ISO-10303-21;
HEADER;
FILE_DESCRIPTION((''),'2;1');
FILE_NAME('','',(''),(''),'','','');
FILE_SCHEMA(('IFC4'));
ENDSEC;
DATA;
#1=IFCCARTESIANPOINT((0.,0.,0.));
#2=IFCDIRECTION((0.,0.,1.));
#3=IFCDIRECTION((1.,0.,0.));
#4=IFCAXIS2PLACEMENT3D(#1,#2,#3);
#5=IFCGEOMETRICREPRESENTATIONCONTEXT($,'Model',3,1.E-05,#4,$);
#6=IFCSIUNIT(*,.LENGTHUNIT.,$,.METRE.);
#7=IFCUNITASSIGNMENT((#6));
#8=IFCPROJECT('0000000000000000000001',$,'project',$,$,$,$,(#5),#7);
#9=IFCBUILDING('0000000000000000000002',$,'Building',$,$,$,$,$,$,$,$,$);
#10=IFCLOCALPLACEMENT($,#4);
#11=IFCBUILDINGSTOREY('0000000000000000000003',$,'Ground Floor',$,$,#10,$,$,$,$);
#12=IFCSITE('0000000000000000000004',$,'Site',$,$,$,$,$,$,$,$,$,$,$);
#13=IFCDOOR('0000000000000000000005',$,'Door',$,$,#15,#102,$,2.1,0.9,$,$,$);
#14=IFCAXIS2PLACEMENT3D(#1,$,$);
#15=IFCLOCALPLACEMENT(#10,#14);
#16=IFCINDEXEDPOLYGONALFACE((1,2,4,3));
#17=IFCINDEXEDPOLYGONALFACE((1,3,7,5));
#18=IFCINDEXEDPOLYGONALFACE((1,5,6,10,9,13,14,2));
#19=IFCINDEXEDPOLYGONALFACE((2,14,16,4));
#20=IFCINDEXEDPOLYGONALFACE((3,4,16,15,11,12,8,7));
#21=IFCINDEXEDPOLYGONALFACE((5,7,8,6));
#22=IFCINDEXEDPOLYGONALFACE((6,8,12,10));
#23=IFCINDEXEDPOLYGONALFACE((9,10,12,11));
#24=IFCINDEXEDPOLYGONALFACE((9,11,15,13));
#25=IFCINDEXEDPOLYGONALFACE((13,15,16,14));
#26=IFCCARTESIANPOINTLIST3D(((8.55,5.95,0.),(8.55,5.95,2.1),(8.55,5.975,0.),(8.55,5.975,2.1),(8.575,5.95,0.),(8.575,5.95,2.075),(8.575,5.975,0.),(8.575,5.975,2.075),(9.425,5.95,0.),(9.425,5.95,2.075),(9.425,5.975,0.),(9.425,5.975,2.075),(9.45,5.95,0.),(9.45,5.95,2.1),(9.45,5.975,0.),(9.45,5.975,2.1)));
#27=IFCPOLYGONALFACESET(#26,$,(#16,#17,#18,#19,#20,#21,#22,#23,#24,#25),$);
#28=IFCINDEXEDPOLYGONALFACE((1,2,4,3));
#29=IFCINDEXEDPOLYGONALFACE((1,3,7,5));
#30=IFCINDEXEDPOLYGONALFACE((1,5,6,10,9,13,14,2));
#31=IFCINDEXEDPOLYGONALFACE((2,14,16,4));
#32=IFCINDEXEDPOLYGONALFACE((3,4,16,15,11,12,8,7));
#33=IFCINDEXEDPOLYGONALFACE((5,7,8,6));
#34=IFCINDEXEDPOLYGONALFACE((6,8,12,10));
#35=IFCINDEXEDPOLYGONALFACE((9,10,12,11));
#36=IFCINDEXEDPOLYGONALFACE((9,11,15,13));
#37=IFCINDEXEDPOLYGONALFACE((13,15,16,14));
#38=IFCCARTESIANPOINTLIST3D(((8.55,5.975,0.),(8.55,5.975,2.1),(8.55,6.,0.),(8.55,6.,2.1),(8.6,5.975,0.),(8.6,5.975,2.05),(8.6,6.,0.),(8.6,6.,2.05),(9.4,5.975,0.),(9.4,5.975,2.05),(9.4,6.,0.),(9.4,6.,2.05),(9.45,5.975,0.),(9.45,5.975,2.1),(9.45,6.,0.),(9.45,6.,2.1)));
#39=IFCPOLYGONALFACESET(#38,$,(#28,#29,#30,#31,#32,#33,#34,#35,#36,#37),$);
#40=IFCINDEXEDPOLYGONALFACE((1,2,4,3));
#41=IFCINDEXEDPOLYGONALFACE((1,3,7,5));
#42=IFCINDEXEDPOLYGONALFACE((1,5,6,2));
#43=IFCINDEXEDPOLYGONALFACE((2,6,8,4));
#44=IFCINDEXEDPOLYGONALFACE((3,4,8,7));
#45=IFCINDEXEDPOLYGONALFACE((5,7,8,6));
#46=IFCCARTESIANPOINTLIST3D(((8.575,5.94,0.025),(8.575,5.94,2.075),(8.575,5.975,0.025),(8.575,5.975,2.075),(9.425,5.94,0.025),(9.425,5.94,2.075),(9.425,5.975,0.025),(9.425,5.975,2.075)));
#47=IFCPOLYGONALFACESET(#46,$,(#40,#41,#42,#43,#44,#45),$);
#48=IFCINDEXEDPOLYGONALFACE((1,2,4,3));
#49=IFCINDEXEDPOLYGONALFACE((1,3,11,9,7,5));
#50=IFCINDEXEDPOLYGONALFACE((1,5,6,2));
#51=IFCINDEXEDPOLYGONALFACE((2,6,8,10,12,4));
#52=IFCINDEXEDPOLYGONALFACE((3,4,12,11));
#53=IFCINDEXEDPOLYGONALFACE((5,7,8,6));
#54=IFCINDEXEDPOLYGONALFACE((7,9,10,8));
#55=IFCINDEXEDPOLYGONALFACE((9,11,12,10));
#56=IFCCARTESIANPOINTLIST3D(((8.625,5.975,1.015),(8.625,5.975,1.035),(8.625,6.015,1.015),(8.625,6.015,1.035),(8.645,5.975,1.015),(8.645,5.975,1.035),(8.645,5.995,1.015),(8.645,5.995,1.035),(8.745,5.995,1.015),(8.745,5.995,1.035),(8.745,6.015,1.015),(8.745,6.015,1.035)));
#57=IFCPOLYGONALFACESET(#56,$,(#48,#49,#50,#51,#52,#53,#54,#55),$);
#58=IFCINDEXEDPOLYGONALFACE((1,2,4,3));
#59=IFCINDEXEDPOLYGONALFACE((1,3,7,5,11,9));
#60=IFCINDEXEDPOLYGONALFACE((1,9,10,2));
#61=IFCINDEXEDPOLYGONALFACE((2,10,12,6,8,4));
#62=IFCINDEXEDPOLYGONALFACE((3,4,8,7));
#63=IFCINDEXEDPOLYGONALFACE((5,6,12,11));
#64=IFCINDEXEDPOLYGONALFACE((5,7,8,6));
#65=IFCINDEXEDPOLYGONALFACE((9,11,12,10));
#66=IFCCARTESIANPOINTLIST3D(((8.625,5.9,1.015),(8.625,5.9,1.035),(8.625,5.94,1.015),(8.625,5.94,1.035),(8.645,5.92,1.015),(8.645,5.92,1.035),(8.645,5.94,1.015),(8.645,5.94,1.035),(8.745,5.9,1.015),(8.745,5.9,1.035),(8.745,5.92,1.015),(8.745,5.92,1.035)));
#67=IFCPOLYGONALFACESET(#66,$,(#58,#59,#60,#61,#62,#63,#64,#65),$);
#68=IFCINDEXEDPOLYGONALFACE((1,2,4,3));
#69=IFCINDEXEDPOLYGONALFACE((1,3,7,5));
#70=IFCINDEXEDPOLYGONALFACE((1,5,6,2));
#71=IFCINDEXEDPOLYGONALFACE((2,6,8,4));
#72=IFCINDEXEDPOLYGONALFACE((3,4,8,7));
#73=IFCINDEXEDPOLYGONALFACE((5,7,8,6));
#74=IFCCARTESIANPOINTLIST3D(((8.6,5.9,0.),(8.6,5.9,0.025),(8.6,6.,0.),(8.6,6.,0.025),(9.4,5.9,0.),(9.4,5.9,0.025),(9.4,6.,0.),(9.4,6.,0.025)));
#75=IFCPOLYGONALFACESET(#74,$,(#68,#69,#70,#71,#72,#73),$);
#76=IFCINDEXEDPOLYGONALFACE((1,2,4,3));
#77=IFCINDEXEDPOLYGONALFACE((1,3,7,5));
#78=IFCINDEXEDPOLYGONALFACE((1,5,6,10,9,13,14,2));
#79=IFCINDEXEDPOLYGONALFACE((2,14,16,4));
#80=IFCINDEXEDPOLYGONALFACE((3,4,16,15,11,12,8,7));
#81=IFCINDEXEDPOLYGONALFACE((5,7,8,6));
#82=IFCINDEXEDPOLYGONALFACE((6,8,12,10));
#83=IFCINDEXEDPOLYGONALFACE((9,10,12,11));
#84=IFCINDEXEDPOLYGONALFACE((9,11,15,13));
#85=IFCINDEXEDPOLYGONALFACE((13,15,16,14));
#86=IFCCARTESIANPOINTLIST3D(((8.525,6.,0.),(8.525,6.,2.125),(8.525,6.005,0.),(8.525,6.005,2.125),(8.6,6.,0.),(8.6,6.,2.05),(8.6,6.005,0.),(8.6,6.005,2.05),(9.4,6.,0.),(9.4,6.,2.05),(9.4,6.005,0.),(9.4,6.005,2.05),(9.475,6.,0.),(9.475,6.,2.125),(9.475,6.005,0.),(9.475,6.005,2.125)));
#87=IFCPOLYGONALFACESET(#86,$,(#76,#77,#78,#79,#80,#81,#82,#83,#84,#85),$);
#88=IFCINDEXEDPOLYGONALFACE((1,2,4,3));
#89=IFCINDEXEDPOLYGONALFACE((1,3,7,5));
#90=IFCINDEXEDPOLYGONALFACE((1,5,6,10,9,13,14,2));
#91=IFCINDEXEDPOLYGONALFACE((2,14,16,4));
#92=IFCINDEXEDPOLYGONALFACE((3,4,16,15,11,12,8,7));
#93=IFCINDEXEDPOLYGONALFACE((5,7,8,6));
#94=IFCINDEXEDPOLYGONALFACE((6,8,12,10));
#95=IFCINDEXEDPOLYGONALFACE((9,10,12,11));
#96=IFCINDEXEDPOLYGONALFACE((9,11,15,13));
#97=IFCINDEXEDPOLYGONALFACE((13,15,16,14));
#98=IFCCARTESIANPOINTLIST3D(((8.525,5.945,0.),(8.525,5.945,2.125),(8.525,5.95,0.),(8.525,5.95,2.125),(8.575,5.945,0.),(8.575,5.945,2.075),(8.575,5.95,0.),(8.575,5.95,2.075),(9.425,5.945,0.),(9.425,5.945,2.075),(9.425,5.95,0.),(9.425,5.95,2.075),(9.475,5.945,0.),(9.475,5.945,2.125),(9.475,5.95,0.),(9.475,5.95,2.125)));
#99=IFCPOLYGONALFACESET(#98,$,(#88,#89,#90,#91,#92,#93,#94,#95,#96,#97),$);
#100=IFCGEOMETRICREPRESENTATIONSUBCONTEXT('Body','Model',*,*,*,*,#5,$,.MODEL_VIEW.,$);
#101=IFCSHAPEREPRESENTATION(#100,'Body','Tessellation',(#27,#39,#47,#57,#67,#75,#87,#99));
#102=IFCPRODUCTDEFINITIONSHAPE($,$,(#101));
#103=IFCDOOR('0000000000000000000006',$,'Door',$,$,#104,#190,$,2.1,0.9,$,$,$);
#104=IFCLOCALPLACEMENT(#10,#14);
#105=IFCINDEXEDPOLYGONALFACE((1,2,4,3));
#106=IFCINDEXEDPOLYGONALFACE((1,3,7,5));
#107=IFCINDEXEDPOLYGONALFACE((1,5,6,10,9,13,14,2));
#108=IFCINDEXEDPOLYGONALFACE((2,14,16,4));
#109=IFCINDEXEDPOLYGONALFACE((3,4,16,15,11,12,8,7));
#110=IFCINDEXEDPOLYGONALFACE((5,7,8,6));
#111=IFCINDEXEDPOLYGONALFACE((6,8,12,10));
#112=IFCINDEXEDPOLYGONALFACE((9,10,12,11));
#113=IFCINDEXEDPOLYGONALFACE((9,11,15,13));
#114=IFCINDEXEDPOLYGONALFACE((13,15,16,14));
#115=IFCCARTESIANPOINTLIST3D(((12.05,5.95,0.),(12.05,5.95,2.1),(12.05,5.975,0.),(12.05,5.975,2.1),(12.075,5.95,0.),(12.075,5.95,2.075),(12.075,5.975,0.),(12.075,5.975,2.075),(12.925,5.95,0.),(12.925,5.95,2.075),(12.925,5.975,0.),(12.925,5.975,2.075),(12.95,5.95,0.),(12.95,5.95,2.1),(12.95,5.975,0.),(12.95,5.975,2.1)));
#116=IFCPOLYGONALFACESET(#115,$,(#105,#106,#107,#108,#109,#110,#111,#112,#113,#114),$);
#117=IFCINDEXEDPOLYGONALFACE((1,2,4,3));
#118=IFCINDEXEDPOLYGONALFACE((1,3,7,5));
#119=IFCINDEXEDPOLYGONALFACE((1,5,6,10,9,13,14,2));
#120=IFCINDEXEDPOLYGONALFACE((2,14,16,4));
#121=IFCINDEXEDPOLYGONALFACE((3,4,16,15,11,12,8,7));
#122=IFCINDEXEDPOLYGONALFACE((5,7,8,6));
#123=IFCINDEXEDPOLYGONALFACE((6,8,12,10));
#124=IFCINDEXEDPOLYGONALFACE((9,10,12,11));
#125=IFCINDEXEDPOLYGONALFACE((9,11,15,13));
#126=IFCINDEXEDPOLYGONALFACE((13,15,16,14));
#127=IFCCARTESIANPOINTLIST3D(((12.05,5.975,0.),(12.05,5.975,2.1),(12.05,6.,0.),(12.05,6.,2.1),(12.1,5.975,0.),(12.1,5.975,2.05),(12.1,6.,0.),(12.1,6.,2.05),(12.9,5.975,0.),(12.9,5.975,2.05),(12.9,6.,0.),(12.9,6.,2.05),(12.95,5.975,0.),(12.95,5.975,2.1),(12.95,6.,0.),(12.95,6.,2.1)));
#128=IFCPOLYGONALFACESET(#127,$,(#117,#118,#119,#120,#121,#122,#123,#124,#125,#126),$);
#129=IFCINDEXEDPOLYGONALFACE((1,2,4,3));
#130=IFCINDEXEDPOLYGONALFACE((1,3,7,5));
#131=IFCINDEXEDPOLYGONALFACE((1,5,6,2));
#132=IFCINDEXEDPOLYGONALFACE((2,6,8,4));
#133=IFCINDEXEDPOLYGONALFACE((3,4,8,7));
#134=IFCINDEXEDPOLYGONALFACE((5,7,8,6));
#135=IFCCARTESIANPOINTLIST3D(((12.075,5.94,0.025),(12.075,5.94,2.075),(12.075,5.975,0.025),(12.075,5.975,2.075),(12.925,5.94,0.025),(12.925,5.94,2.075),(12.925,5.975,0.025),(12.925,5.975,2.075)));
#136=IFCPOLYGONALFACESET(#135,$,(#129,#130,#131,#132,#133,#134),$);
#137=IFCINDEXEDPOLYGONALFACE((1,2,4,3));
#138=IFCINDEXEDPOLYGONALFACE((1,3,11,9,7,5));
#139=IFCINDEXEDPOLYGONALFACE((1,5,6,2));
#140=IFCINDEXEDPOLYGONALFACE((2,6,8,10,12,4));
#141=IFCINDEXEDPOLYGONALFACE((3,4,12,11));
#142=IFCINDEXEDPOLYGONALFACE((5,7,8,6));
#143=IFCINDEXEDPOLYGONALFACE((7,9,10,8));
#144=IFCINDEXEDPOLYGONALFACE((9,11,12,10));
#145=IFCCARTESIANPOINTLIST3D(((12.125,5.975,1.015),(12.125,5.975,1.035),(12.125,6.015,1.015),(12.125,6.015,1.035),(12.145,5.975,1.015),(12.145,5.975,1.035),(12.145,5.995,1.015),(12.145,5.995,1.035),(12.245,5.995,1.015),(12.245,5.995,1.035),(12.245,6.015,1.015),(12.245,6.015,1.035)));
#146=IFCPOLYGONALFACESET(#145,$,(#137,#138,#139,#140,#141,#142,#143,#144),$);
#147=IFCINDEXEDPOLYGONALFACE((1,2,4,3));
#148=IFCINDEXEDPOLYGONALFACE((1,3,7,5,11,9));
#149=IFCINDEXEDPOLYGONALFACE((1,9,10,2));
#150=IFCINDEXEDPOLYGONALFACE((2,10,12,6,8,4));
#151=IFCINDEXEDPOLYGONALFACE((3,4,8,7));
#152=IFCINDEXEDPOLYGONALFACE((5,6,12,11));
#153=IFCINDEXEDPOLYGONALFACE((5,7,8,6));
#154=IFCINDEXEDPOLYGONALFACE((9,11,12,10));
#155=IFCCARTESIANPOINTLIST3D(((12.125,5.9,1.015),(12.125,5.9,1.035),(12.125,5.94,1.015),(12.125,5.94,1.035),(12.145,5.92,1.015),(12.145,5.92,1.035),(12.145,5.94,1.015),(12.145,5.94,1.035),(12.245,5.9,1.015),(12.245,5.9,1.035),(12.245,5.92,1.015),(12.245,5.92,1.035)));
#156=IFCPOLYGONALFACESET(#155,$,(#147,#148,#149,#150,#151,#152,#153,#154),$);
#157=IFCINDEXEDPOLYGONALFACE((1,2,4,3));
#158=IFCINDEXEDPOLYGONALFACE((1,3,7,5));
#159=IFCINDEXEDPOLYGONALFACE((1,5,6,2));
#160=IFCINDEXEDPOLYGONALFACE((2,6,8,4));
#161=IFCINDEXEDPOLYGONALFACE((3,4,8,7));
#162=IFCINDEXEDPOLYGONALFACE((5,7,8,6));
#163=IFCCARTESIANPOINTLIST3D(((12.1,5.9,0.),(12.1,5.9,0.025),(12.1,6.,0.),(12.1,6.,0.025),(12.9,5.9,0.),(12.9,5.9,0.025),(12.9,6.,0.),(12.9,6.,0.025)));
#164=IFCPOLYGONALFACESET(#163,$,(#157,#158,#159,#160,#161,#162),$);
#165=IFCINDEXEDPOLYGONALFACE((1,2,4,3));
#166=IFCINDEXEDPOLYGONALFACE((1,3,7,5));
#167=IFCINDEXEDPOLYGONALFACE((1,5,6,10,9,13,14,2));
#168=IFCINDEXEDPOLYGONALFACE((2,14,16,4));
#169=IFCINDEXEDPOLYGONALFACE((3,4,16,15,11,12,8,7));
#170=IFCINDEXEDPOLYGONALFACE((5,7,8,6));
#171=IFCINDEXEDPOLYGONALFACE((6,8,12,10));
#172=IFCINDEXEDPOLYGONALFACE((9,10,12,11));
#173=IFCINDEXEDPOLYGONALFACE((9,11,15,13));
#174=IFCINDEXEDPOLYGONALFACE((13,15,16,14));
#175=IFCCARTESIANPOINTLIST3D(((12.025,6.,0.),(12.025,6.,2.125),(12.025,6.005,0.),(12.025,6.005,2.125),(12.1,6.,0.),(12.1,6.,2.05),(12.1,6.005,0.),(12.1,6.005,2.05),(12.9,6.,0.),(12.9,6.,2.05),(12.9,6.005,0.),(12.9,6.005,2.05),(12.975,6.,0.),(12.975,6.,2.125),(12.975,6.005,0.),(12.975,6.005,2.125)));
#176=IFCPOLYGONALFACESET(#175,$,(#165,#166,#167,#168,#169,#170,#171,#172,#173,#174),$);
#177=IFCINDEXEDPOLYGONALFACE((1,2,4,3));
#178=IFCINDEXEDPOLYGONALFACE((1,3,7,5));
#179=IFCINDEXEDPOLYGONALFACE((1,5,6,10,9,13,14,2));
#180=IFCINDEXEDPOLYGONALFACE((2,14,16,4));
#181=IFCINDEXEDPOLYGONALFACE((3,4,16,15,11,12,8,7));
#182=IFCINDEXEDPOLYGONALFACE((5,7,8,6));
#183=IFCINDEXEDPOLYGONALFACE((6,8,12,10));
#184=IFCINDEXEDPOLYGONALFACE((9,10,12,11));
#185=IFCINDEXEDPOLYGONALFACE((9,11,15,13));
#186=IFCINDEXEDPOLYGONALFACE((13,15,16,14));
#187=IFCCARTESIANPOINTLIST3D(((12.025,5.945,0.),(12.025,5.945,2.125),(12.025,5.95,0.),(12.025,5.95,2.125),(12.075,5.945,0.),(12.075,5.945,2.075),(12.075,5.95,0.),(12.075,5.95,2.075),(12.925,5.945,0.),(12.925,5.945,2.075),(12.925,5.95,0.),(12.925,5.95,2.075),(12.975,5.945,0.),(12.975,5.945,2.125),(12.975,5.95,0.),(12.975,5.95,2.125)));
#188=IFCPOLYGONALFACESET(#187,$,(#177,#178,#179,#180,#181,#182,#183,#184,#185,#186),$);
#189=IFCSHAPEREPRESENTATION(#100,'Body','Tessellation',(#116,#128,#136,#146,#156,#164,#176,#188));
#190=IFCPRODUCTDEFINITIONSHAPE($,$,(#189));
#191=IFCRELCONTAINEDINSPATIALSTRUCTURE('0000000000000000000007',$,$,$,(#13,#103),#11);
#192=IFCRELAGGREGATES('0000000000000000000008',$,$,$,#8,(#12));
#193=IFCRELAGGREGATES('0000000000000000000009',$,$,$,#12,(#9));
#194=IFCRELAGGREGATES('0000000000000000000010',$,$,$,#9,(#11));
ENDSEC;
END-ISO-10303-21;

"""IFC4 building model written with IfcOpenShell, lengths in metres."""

from ifc_helpers import new_model, si_unit, frame, origin_with_axes, place, context, subcontext, project, spatial, line, indexed_curve, outline, extrude, element, save


model = new_model("IFC4")

# Units and contexts
model_context = context("Model", 3, precision=1e-05, world=origin_with_axes())
body_context = subcontext(model_context, "Body", "Model", "MODEL_VIEW")
ifc_project = project(units=[si_unit("LENGTHUNIT", "METRE")], contexts=[model_context])

# Site, building, storey
site = spatial("IfcSite", under=ifc_project, Name="Site")
building = spatial("IfcBuilding", under=site, Name="Building")
storey_placement = place(None, origin_with_axes())
storey = spatial("IfcBuildingStorey", under=building, at=storey_placement, Name="Ground Floor")

# Doors
door_1_placement = place(storey_placement, frame((9.45, 6.0, 0.0), z_axis=(0.0, 0.0, 1.0), x_axis=(-1.0, 0.0, 0.0)))
element("IfcDoor", 1, at=door_1_placement, inside=storey, Name="Door", OverallHeight=2.1, OverallWidth=0.9, context=body_context, shape_type="SweptSolid", body=[
    extrude(outline(indexed_curve([(0.0, 0.0), (0.0, 2.1), (0.9, 2.1), (0.9, 0.0), (0.875, 0.0), (0.875, 2.075), (0.025, 2.075), (0.025, 0.0)], segments=[line(1, 2, 3, 4, 5, 6, 7, 8, 1)])), frame((0.0, 0.025, 0.0), z_axis=(0.0, -1.0, 0.0), x_axis=(1.0, 0.0, 0.0)), (0.0, 0.0, -1.0), 0.025),
    extrude(outline(indexed_curve([(0.0, 0.0), (0.0, 2.1), (0.9, 2.1), (0.9, 0.0), (0.85, 0.0), (0.85, 2.05), (0.05, 2.05), (0.05, 0.0)], segments=[line(1, 2, 3, 4, 5, 6, 7, 8, 1)])), frame((0.0, 0.0, 0.0), z_axis=(0.0, -1.0, 0.0), x_axis=(1.0, 0.0, 0.0)), (0.0, 0.0, -1.0), 0.025),
    extrude(outline(indexed_curve([(0.0, 0.0), (0.85, 0.0), (0.85, 0.035), (0.0, 0.035)], segments=[line(1, 2, 3, 4, 1)])), frame((0.025, 0.025, 0.025), z_axis=(0.0, 0.0, 1.0), x_axis=(1.0, 0.0, 0.0)), (0.0, 0.0, 1.0), 2.05),
    extrude(outline(indexed_curve([(0.0, 0.0), (0.0, -0.04), (-0.12, -0.04), (-0.12, -0.02), (-0.02, -0.02), (-0.02, 0.0)], segments=[line(1, 2, 3, 4, 5, 6, 1)])), frame((0.825, 0.025, 1.015), z_axis=(0.0, 0.0, 1.0), x_axis=(1.0, 0.0, 0.0)), (0.0, 0.0, 1.0), 0.02),
    extrude(outline(indexed_curve([(0.0, 0.0), (0.0, 0.04), (-0.12, 0.04), (-0.12, 0.02), (-0.02, 0.02), (-0.02, 0.0)], segments=[line(1, 2, 3, 4, 5, 6, 1)])), frame((0.825, 0.06, 1.015), z_axis=(0.0, 0.0, 1.0), x_axis=(1.0, 0.0, 0.0)), (0.0, 0.0, 1.0), 0.02),
    extrude(outline(indexed_curve([(0.0, 0.0), (0.8, 0.0), (0.8, 0.1), (0.0, 0.1)], segments=[line(1, 2, 3, 4, 1)])), frame((0.05, 0.0, 0.0), z_axis=(0.0, 0.0, 1.0), x_axis=(1.0, 0.0, 0.0)), (0.0, 0.0, 1.0), 0.025),
    extrude(outline(indexed_curve([(0.0, 0.0), (0.0, 2.125), (0.95, 2.125), (0.95, 0.0), (0.875, 0.0), (0.875, 2.05), (0.075, 2.05), (0.075, 0.0)], segments=[line(1, 2, 3, 4, 5, 6, 7, 8, 1)])), frame((-0.025, -0.005, 0.0), z_axis=(0.0, -1.0, 0.0), x_axis=(1.0, 0.0, 0.0)), (0.0, 0.0, -1.0), 0.005),
    extrude(outline(indexed_curve([(0.0, 0.0), (0.0, 2.125), (0.95, 2.125), (0.95, 0.0), (0.9, 0.0), (0.9, 2.075), (0.05, 2.075), (0.05, 0.0)], segments=[line(1, 2, 3, 4, 5, 6, 7, 8, 1)])), frame((-0.025, 0.05, 0.0), z_axis=(0.0, -1.0, 0.0), x_axis=(1.0, 0.0, 0.0)), (0.0, 0.0, -1.0), 0.005),
])
door_2_placement = place(storey_placement, frame((12.95, 6.0, 0.0), z_axis=(0.0, 0.0, 1.0), x_axis=(-1.0, 0.0, 0.0)))
element("IfcDoor", 2, at=door_2_placement, inside=storey, Name="Door", OverallHeight=2.1, OverallWidth=0.9, context=body_context, shape_type="SweptSolid", body=[
    extrude(outline(indexed_curve([(0.0, 0.0), (0.0, 2.1), (0.9, 2.1), (0.9, 0.0), (0.875, 0.0), (0.875, 2.075), (0.025, 2.075), (0.025, 0.0)], segments=[line(1, 2, 3, 4, 5, 6, 7, 8, 1)])), frame((0.0, 0.025, 0.0), z_axis=(0.0, -1.0, 0.0), x_axis=(1.0, 0.0, 0.0)), (0.0, 0.0, -1.0), 0.025),
    extrude(outline(indexed_curve([(0.0, 0.0), (0.0, 2.1), (0.9, 2.1), (0.9, 0.0), (0.85, 0.0), (0.85, 2.05), (0.05, 2.05), (0.05, 0.0)], segments=[line(1, 2, 3, 4, 5, 6, 7, 8, 1)])), frame((0.0, 0.0, 0.0), z_axis=(0.0, -1.0, 0.0), x_axis=(1.0, 0.0, 0.0)), (0.0, 0.0, -1.0), 0.025),
    extrude(outline(indexed_curve([(0.0, 0.0), (0.85, 0.0), (0.85, 0.035), (0.0, 0.035)], segments=[line(1, 2, 3, 4, 1)])), frame((0.025, 0.025, 0.025), z_axis=(0.0, 0.0, 1.0), x_axis=(1.0, 0.0, 0.0)), (0.0, 0.0, 1.0), 2.05),
    extrude(outline(indexed_curve([(0.0, 0.0), (0.0, -0.04), (-0.12, -0.04), (-0.12, -0.02), (-0.02, -0.02), (-0.02, 0.0)], segments=[line(1, 2, 3, 4, 5, 6, 1)])), frame((0.825, 0.025, 1.015), z_axis=(0.0, 0.0, 1.0), x_axis=(1.0, 0.0, 0.0)), (0.0, 0.0, 1.0), 0.02),
    extrude(outline(indexed_curve([(0.0, 0.0), (0.0, 0.04), (-0.12, 0.04), (-0.12, 0.02), (-0.02, 0.02), (-0.02, 0.0)], segments=[line(1, 2, 3, 4, 5, 6, 1)])), frame((0.825, 0.06, 1.015), z_axis=(0.0, 0.0, 1.0), x_axis=(1.0, 0.0, 0.0)), (0.0, 0.0, 1.0), 0.02),
    extrude(outline(indexed_curve([(0.0, 0.0), (0.8, 0.0), (0.8, 0.1), (0.0, 0.1)], segments=[line(1, 2, 3, 4, 1)])), frame((0.05, 0.0, 0.0), z_axis=(0.0, 0.0, 1.0), x_axis=(1.0, 0.0, 0.0)), (0.0, 0.0, 1.0), 0.025),
    extrude(outline(indexed_curve([(0.0, 0.0), (0.0, 2.125), (0.95, 2.125), (0.95, 0.0), (0.875, 0.0), (0.875, 2.05), (0.075, 2.05), (0.075, 0.0)], segments=[line(1, 2, 3, 4, 5, 6, 7, 8, 1)])), frame((-0.025, -0.005, 0.0), z_axis=(0.0, -1.0, 0.0), x_axis=(1.0, 0.0, 0.0)), (0.0, 0.0, -1.0), 0.005),
    extrude(outline(indexed_curve([(0.0, 0.0), (0.0, 2.125), (0.95, 2.125), (0.95, 0.0), (0.9, 0.0), (0.9, 2.075), (0.05, 2.075), (0.05, 0.0)], segments=[line(1, 2, 3, 4, 5, 6, 7, 8, 1)])), frame((-0.025, 0.05, 0.0), z_axis=(0.0, -1.0, 0.0), x_axis=(1.0, 0.0, 0.0)), (0.0, 0.0, -1.0), 0.005),
])

save(model, "model.ifc")
